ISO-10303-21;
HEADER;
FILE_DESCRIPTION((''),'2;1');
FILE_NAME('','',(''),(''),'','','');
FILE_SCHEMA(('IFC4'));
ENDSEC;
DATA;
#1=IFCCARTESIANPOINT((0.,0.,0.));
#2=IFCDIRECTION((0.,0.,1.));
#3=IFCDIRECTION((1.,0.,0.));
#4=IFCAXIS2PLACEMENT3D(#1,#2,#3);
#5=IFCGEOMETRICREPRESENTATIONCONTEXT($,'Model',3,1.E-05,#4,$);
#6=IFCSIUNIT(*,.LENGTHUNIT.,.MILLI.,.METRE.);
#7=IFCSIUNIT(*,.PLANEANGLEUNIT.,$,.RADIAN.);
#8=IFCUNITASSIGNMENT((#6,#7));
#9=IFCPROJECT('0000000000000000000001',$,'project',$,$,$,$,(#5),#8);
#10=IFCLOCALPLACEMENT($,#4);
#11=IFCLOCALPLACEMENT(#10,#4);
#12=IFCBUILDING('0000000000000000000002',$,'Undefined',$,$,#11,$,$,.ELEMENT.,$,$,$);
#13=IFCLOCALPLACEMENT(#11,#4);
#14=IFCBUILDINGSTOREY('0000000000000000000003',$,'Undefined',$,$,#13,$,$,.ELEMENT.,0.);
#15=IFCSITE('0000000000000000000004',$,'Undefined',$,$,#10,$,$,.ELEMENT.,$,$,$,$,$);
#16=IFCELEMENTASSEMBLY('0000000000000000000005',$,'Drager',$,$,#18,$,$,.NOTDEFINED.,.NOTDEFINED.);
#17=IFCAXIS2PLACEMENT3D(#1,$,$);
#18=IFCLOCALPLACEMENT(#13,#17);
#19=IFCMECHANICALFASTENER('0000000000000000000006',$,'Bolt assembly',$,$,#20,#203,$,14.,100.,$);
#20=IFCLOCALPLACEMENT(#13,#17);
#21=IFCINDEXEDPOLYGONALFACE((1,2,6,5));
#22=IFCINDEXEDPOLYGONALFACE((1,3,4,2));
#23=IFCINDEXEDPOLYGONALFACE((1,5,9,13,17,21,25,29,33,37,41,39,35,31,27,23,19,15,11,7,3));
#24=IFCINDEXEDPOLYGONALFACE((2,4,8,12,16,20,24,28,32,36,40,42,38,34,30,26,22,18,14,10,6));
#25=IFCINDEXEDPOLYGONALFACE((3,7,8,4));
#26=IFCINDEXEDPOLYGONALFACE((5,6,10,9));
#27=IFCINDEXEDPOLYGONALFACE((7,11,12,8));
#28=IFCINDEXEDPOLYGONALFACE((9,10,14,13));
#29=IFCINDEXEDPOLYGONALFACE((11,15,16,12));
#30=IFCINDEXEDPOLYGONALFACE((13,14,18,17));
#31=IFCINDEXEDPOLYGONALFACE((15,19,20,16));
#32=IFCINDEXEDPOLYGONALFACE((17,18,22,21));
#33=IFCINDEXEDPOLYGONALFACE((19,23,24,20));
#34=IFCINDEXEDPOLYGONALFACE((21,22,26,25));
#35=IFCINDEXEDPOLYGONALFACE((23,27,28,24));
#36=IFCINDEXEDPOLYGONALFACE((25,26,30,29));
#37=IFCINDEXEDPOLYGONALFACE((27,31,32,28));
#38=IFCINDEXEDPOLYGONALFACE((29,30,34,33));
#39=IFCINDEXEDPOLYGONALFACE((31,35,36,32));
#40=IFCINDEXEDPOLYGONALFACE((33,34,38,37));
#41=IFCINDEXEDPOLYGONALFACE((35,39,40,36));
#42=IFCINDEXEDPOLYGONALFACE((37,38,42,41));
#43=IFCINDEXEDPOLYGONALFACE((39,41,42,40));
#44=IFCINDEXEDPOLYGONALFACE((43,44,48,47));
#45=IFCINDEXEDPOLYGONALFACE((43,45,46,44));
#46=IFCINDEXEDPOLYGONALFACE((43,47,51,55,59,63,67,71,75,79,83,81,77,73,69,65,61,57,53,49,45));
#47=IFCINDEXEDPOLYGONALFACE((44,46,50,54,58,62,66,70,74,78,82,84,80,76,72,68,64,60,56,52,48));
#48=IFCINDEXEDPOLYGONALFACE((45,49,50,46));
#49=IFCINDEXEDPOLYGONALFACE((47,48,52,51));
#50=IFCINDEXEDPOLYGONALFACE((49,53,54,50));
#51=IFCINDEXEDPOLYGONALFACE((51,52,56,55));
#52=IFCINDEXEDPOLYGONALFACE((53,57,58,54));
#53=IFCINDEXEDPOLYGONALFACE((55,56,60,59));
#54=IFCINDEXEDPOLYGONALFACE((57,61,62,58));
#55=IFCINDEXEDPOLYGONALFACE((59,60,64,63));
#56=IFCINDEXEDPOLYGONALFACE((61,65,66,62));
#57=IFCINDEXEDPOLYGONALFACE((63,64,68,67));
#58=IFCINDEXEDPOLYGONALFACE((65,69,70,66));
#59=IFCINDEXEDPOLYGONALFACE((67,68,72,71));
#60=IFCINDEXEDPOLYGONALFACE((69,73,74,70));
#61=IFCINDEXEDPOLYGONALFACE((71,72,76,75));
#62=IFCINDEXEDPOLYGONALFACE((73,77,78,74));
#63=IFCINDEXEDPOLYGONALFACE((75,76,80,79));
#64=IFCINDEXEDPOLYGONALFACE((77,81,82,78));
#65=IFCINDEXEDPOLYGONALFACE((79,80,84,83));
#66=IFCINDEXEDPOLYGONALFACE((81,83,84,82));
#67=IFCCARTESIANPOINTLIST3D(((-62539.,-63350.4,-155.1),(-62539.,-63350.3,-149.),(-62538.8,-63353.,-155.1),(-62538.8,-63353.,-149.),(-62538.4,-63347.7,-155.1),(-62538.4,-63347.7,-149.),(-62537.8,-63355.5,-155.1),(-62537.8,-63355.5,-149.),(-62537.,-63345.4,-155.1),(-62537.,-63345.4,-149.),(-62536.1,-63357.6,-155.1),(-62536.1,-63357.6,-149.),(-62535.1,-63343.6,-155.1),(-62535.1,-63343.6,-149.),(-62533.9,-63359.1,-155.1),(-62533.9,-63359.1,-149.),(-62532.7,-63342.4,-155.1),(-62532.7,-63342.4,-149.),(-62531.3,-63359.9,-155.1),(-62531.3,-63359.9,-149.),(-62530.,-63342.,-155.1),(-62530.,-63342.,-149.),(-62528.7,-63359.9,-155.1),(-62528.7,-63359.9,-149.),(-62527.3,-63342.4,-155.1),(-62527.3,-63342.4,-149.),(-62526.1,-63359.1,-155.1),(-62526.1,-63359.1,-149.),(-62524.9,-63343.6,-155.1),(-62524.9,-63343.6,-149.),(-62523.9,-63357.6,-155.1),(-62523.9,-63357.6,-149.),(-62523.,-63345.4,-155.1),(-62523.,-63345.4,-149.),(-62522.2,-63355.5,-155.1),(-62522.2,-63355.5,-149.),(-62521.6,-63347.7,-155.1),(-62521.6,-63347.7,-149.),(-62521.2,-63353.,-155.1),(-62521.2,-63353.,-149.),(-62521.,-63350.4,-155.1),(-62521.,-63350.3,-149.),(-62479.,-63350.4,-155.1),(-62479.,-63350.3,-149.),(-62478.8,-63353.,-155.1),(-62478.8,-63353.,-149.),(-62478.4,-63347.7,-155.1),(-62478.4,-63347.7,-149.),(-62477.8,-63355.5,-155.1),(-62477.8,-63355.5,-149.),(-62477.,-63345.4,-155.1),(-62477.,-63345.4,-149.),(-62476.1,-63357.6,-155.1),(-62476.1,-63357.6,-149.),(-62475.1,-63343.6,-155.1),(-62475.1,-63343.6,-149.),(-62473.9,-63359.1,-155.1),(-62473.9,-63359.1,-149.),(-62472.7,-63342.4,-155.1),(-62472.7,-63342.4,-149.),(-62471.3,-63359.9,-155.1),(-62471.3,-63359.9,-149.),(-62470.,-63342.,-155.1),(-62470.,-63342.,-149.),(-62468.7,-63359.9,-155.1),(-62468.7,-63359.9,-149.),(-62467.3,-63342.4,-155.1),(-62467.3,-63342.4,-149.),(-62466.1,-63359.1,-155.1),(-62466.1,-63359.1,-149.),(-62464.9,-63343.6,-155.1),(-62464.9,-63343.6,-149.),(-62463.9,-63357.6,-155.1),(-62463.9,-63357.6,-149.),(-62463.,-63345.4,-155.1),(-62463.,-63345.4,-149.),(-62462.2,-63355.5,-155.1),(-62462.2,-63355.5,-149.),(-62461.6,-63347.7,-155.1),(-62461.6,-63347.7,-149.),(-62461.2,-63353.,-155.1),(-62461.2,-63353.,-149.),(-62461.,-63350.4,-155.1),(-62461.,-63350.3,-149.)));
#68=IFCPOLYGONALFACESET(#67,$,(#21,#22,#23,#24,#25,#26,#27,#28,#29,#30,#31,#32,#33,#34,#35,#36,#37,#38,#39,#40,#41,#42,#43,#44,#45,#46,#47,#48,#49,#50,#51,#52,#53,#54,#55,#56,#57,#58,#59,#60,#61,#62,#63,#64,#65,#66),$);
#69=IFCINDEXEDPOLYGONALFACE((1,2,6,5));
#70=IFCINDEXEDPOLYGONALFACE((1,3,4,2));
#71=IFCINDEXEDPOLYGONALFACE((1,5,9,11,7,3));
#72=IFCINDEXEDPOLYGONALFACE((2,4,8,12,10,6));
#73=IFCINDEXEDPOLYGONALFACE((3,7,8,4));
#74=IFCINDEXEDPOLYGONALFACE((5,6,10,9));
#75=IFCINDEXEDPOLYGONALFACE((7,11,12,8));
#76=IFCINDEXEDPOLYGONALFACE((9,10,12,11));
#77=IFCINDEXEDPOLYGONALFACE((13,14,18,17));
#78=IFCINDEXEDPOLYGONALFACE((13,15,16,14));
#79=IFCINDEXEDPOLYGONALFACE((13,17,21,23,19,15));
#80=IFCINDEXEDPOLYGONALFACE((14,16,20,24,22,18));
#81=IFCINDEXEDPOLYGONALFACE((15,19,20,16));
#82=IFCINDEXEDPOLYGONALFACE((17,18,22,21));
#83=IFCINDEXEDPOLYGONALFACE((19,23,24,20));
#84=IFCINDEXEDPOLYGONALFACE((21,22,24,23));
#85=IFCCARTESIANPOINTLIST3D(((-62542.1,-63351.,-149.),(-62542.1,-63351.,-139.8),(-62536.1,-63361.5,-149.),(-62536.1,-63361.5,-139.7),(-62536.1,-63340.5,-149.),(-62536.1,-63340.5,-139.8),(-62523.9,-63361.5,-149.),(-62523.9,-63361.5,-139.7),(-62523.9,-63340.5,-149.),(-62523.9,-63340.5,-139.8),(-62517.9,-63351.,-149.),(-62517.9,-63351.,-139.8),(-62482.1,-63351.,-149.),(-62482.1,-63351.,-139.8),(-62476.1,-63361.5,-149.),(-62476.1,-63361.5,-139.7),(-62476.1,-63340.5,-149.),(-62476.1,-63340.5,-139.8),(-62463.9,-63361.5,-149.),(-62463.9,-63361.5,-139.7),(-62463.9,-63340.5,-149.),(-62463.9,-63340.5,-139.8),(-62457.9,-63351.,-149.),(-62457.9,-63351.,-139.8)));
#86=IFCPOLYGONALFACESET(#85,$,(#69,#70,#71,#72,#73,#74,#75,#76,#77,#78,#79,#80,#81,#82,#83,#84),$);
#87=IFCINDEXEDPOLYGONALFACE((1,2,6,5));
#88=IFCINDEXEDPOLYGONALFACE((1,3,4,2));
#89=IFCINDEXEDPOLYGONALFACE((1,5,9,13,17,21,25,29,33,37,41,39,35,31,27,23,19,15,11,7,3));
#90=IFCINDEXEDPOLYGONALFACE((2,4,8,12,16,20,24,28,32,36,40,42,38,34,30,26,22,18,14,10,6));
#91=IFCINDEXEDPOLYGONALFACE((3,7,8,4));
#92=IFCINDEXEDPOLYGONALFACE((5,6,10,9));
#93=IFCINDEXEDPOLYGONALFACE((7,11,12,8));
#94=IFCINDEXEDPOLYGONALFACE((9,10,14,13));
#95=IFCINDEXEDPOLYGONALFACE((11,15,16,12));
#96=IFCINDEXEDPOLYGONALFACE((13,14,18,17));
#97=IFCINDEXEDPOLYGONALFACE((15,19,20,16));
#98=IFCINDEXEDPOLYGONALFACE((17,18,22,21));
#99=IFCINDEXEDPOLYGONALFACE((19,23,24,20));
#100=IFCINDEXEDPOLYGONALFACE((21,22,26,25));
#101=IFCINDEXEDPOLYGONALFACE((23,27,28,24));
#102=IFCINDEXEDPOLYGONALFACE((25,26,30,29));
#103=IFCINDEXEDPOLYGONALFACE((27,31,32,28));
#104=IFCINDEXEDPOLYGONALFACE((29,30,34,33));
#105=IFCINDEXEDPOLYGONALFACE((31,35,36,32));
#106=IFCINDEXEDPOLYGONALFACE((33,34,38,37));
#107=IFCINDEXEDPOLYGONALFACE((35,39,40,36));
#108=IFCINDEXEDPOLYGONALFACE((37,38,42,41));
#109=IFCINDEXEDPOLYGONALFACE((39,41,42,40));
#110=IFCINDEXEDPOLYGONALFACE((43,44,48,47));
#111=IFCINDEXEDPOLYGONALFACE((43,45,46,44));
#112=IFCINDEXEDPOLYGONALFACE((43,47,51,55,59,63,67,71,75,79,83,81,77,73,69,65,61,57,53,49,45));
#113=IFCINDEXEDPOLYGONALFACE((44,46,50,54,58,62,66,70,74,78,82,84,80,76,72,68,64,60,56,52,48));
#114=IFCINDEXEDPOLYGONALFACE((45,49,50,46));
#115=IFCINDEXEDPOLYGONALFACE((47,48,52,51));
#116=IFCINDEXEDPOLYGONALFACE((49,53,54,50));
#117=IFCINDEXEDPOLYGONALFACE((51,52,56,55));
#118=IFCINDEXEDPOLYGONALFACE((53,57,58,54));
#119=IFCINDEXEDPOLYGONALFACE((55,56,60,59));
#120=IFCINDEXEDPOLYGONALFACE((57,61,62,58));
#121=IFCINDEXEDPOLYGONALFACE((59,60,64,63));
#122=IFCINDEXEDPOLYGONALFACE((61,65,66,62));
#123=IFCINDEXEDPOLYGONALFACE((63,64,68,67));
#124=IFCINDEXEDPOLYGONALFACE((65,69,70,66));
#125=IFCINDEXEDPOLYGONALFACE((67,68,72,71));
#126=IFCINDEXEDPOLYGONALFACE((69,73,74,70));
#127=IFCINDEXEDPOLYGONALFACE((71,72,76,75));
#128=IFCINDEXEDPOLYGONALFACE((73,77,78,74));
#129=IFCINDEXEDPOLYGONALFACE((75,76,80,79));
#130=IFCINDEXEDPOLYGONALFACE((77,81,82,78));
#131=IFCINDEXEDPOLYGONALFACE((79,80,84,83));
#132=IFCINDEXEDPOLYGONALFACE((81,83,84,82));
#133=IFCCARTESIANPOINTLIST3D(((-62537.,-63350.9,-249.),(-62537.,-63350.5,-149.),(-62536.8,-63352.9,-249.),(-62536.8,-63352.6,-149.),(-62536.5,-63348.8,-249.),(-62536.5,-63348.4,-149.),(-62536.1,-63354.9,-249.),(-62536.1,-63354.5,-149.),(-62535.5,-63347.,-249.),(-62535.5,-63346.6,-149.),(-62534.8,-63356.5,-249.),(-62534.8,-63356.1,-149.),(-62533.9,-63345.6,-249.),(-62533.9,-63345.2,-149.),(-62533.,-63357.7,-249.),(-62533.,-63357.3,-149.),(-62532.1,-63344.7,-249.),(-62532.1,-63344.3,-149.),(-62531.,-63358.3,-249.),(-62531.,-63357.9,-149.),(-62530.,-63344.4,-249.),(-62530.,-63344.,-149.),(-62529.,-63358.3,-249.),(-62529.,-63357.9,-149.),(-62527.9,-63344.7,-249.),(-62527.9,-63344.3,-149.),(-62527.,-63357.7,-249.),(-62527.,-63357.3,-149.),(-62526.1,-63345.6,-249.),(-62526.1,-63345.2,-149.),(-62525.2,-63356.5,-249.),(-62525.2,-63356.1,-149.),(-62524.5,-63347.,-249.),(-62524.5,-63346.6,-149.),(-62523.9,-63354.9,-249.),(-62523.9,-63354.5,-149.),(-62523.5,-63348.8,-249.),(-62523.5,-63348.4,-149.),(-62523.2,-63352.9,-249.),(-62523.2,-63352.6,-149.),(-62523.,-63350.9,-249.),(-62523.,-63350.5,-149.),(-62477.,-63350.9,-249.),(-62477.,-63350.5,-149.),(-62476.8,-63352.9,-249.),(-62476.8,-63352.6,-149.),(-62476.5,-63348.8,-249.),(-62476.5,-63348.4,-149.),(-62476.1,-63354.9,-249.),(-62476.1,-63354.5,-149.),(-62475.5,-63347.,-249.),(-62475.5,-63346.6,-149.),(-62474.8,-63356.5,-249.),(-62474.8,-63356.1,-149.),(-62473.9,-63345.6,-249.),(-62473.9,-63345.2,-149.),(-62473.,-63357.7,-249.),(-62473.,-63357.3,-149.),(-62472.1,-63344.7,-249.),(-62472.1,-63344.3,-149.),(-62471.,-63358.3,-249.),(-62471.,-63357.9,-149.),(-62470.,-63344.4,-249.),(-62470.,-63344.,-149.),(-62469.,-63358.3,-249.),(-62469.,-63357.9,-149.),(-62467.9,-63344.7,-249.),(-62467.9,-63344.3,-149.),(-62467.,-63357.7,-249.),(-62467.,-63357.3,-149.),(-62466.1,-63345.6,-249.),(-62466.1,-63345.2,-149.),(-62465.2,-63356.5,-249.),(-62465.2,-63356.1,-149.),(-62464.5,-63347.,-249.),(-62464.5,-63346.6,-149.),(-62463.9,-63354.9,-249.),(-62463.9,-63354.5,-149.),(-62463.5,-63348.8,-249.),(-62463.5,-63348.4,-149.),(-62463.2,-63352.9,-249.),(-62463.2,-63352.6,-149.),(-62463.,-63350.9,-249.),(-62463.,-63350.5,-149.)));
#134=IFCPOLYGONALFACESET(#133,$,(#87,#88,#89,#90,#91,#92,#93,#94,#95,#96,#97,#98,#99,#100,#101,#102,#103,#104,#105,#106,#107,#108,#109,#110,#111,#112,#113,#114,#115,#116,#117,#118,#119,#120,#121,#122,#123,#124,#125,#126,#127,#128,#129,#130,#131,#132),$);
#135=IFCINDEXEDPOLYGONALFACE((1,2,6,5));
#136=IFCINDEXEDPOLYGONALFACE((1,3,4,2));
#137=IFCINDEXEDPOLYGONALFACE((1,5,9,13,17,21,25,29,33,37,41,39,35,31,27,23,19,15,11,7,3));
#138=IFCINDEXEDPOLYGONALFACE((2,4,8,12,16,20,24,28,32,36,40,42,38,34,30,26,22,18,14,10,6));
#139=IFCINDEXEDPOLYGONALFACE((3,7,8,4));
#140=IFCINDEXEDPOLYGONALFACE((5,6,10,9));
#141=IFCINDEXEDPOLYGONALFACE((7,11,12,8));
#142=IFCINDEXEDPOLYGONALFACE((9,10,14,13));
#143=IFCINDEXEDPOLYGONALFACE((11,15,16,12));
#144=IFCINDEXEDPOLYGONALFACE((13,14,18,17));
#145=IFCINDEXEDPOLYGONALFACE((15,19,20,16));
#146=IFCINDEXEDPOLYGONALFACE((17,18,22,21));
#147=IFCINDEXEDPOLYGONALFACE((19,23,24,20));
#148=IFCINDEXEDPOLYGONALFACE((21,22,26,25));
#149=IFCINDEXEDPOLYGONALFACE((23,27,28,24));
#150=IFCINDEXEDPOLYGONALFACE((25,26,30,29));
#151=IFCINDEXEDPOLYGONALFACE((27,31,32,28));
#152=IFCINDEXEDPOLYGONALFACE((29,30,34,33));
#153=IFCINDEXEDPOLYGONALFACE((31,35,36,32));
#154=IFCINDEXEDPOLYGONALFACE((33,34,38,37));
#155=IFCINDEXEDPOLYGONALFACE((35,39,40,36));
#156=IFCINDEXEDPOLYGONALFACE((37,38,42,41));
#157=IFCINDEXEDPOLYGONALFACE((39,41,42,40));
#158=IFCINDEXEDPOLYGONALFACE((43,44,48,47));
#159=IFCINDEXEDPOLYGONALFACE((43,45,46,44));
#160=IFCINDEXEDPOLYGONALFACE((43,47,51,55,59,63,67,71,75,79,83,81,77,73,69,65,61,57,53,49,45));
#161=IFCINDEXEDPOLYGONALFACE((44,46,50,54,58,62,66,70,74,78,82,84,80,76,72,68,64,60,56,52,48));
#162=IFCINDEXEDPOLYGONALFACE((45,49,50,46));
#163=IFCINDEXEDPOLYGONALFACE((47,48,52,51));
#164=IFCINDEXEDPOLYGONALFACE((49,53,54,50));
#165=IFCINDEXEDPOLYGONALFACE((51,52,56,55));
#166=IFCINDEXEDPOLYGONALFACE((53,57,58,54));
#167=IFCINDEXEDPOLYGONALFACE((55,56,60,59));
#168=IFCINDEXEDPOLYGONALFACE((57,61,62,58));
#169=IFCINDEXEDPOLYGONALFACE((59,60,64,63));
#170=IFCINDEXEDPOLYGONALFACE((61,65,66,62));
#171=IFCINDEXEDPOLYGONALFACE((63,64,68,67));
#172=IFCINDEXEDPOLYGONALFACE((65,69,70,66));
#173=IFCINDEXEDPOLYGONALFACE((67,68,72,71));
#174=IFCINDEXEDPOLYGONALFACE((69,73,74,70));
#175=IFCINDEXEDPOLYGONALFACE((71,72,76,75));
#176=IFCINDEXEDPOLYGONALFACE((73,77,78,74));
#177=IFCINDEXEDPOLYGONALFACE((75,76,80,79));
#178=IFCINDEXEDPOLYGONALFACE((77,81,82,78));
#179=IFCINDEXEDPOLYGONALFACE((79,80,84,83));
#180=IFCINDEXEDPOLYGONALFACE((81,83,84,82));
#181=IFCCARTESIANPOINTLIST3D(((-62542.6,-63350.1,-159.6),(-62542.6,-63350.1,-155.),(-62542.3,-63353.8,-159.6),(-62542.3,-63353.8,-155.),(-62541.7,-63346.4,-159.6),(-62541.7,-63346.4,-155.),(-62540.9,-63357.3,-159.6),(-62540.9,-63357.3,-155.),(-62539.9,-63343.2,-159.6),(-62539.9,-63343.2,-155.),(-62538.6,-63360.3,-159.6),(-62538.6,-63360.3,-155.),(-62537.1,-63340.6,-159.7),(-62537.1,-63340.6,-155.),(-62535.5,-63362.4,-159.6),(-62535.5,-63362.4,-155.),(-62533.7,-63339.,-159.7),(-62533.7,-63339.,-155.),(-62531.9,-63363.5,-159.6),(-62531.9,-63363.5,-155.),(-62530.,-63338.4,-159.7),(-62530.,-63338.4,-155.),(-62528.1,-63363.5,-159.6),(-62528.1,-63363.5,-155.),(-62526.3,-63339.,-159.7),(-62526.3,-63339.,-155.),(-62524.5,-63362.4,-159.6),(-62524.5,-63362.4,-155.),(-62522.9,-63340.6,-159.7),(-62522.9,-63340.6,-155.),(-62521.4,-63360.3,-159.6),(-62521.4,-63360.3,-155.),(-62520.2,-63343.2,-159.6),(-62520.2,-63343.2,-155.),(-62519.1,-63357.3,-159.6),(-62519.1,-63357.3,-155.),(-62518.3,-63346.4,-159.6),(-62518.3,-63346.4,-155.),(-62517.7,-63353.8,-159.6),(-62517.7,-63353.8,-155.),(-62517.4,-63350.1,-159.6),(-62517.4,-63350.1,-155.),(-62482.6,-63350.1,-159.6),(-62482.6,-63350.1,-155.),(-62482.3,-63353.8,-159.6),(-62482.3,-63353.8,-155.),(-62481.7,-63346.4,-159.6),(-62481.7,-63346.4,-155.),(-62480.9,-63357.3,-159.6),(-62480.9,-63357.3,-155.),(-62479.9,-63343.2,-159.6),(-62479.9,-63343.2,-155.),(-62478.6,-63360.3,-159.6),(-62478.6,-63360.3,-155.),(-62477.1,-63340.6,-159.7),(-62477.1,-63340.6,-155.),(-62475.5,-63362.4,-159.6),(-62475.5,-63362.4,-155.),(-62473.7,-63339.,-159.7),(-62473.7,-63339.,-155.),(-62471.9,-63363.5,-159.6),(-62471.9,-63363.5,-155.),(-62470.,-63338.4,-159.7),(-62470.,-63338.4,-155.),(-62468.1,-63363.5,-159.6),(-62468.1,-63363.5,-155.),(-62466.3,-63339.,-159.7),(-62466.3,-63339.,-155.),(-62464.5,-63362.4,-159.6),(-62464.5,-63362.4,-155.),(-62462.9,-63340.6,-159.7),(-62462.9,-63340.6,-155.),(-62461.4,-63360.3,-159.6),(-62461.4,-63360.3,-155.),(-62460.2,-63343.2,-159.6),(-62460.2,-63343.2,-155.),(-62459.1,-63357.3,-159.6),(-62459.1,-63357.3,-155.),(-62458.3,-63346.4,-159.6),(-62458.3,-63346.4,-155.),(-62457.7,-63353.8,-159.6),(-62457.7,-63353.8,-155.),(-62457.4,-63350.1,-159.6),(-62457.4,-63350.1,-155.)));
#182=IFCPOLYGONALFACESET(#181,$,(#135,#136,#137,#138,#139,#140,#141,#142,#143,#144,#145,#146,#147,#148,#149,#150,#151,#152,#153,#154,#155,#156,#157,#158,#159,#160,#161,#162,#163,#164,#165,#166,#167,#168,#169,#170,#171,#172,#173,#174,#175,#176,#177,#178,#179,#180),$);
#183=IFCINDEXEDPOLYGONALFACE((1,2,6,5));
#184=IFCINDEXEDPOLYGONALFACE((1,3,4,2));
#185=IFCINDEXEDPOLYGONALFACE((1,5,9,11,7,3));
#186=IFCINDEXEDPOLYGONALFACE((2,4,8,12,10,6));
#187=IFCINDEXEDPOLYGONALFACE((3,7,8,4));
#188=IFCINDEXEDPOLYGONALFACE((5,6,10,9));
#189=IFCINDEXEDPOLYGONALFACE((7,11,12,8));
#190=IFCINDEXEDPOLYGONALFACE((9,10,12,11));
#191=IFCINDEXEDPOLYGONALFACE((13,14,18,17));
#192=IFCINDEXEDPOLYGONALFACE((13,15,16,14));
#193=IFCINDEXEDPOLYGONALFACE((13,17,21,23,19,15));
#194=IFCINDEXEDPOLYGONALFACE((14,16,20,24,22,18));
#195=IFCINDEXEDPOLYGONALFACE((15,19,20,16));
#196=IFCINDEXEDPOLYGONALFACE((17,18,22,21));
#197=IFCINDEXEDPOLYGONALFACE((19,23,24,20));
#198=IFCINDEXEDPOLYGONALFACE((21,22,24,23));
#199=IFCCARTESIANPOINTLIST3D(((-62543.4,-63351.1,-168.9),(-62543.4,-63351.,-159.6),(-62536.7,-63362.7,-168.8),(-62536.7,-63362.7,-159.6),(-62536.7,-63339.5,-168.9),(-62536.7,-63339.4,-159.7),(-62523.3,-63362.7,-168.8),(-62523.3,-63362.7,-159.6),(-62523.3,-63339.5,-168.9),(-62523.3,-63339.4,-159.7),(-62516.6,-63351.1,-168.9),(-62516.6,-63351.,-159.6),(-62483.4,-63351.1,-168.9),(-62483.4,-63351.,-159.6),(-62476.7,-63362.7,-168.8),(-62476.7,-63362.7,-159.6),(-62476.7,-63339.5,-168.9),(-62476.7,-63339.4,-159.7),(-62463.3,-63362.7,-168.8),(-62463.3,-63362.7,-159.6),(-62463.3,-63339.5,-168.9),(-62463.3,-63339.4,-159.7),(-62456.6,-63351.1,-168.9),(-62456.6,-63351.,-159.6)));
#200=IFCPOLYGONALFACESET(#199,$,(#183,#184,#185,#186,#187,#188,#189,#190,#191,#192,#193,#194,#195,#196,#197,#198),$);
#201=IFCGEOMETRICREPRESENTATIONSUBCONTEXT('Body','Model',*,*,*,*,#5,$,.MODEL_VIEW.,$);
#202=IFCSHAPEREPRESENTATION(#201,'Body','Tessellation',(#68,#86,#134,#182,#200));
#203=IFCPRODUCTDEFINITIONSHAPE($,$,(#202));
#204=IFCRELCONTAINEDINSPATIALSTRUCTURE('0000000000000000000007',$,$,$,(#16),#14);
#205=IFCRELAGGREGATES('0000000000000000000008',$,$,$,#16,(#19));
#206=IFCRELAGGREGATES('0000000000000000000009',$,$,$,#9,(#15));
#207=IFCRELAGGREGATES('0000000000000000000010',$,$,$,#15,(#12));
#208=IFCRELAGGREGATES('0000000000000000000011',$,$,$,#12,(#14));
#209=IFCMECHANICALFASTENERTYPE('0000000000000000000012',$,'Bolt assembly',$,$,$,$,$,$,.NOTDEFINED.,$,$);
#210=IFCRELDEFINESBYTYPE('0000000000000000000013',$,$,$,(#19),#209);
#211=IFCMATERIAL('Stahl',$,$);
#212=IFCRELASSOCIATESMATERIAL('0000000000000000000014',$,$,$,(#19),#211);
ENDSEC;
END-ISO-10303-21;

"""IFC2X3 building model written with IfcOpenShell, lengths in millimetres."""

from ifc_helpers import new_model, si_unit, frame, origin_with_axes, origin_2d_with_axis, place, context, subcontext, project, spatial, polyline, circle, outline, extrude, source, transform, mapped, material, type_object, element, aggregate, save


model = new_model("IFC2X3")

# Units and contexts
model_context = context("Model", 3, precision=1e-05, world=origin_with_axes())
body_context = subcontext(model_context, "Body", "Model", "MODEL_VIEW")
ifc_project = project(units=[si_unit("LENGTHUNIT", "METRE", prefix="MILLI"), si_unit("PLANEANGLEUNIT", "RADIAN")], contexts=[model_context])

# Site, building, storey
site_placement = place(None, origin_with_axes())
site = spatial("IfcSite", under=ifc_project, at=site_placement, Name="Undefined", CompositionType="ELEMENT")
building_placement = place(site_placement, origin_with_axes())
building = spatial("IfcBuilding", under=site, at=building_placement, Name="Undefined", CompositionType="ELEMENT")
storey_placement = place(building_placement, origin_with_axes())
storey = spatial("IfcBuildingStorey", under=building, at=storey_placement, Name="Undefined", CompositionType="ELEMENT", Elevation=0.0)

# Element assembly
assembly_1_placement = place(storey_placement, origin_with_axes())
assembly_1 = element("IfcElementAssembly", 1, at=assembly_1_placement, inside=storey, Name="Drager", AssemblyPlace="NOTDEFINED", PredefinedType="NOTDEFINED")

# Shared definitions
mechanical_fastener_type = type_object("IfcMechanicalFastenerType", Name="Bolt assembly")
ifc_material_1 = material(Name="Stahl")

# Mechanical fastener
shared_shape_1 = source(origin_with_axes(), body_context, "Body", "SweptSolid", [
    extrude(circle(Radius=9.0, at=origin_2d_with_axis()), frame((0.0, 0.2, 0.0), z_axis=(0.0, 1.0, 0.0), x_axis=(1.0, 0.0, 0.0)), (0.0, 0.0, 1.0), 6.1),
    extrude(outline(polyline([(10.5, -6.1), (10.5, 6.1), (0.0, 12.1), (-10.5, 6.1), (-10.5, -6.1), (0.0, -12.1), (10.5, -6.1)])), frame((0.0, -9.1, 0.0), z_axis=(0.0, 1.0, 0.0), x_axis=(1.0, 0.0, 0.0)), (0.0, 0.0, 1.0), 9.2),
    extrude(circle(Radius=7.0, at=origin_2d_with_axis()), frame((0.0, 0.2, 0.0), z_axis=(0.0, 1.0, 0.0), x_axis=(1.0, 0.0, 0.0)), (0.0, 0.0, 1.0), 100.0),
    extrude(circle(Radius=12.6, at=origin_2d_with_axis()), frame((0.0, 6.2, 0.0), z_axis=(0.0, 1.0, 0.0), x_axis=(1.0, 0.0, 0.0)), (0.0, 0.0, 1.0), 4.6),
    extrude(outline(polyline([(11.6, -6.7), (11.6, 6.7), (0.0, 13.4), (-11.6, 6.7), (-11.6, -6.7), (0.0, -13.4), (11.6, -6.7)])), frame((0.0, 10.8, 0.0), z_axis=(0.0, 1.0, 0.0), x_axis=(1.0, 0.0, 0.0)), (0.0, 0.0, 1.0), 9.2),
])
mechanical_fastener_1_placement = place(assembly_1_placement, frame((-62500.0, -63351.0, -148.8), z_axis=(-1.0, 0.0, 0.0), x_axis=(-0.000001, 0.999993, -0.00375)))
mechanical_fastener_1 = element("IfcMechanicalFastener", 2, at=mechanical_fastener_1_placement, type_object=mechanical_fastener_type, material=ifc_material_1, Name="Bolt assembly", NominalDiameter=14.0, NominalLength=100.0, context=body_context, shape_type="MappedRepresentation", body=[
    mapped(shared_shape_1, transform((0.0, 0.0, -30.0))),
    mapped(shared_shape_1, transform((0.0, 0.0, 30.0))),
])
aggregate(assembly_1, [mechanical_fastener_1])

save(model, "model.ifc")
